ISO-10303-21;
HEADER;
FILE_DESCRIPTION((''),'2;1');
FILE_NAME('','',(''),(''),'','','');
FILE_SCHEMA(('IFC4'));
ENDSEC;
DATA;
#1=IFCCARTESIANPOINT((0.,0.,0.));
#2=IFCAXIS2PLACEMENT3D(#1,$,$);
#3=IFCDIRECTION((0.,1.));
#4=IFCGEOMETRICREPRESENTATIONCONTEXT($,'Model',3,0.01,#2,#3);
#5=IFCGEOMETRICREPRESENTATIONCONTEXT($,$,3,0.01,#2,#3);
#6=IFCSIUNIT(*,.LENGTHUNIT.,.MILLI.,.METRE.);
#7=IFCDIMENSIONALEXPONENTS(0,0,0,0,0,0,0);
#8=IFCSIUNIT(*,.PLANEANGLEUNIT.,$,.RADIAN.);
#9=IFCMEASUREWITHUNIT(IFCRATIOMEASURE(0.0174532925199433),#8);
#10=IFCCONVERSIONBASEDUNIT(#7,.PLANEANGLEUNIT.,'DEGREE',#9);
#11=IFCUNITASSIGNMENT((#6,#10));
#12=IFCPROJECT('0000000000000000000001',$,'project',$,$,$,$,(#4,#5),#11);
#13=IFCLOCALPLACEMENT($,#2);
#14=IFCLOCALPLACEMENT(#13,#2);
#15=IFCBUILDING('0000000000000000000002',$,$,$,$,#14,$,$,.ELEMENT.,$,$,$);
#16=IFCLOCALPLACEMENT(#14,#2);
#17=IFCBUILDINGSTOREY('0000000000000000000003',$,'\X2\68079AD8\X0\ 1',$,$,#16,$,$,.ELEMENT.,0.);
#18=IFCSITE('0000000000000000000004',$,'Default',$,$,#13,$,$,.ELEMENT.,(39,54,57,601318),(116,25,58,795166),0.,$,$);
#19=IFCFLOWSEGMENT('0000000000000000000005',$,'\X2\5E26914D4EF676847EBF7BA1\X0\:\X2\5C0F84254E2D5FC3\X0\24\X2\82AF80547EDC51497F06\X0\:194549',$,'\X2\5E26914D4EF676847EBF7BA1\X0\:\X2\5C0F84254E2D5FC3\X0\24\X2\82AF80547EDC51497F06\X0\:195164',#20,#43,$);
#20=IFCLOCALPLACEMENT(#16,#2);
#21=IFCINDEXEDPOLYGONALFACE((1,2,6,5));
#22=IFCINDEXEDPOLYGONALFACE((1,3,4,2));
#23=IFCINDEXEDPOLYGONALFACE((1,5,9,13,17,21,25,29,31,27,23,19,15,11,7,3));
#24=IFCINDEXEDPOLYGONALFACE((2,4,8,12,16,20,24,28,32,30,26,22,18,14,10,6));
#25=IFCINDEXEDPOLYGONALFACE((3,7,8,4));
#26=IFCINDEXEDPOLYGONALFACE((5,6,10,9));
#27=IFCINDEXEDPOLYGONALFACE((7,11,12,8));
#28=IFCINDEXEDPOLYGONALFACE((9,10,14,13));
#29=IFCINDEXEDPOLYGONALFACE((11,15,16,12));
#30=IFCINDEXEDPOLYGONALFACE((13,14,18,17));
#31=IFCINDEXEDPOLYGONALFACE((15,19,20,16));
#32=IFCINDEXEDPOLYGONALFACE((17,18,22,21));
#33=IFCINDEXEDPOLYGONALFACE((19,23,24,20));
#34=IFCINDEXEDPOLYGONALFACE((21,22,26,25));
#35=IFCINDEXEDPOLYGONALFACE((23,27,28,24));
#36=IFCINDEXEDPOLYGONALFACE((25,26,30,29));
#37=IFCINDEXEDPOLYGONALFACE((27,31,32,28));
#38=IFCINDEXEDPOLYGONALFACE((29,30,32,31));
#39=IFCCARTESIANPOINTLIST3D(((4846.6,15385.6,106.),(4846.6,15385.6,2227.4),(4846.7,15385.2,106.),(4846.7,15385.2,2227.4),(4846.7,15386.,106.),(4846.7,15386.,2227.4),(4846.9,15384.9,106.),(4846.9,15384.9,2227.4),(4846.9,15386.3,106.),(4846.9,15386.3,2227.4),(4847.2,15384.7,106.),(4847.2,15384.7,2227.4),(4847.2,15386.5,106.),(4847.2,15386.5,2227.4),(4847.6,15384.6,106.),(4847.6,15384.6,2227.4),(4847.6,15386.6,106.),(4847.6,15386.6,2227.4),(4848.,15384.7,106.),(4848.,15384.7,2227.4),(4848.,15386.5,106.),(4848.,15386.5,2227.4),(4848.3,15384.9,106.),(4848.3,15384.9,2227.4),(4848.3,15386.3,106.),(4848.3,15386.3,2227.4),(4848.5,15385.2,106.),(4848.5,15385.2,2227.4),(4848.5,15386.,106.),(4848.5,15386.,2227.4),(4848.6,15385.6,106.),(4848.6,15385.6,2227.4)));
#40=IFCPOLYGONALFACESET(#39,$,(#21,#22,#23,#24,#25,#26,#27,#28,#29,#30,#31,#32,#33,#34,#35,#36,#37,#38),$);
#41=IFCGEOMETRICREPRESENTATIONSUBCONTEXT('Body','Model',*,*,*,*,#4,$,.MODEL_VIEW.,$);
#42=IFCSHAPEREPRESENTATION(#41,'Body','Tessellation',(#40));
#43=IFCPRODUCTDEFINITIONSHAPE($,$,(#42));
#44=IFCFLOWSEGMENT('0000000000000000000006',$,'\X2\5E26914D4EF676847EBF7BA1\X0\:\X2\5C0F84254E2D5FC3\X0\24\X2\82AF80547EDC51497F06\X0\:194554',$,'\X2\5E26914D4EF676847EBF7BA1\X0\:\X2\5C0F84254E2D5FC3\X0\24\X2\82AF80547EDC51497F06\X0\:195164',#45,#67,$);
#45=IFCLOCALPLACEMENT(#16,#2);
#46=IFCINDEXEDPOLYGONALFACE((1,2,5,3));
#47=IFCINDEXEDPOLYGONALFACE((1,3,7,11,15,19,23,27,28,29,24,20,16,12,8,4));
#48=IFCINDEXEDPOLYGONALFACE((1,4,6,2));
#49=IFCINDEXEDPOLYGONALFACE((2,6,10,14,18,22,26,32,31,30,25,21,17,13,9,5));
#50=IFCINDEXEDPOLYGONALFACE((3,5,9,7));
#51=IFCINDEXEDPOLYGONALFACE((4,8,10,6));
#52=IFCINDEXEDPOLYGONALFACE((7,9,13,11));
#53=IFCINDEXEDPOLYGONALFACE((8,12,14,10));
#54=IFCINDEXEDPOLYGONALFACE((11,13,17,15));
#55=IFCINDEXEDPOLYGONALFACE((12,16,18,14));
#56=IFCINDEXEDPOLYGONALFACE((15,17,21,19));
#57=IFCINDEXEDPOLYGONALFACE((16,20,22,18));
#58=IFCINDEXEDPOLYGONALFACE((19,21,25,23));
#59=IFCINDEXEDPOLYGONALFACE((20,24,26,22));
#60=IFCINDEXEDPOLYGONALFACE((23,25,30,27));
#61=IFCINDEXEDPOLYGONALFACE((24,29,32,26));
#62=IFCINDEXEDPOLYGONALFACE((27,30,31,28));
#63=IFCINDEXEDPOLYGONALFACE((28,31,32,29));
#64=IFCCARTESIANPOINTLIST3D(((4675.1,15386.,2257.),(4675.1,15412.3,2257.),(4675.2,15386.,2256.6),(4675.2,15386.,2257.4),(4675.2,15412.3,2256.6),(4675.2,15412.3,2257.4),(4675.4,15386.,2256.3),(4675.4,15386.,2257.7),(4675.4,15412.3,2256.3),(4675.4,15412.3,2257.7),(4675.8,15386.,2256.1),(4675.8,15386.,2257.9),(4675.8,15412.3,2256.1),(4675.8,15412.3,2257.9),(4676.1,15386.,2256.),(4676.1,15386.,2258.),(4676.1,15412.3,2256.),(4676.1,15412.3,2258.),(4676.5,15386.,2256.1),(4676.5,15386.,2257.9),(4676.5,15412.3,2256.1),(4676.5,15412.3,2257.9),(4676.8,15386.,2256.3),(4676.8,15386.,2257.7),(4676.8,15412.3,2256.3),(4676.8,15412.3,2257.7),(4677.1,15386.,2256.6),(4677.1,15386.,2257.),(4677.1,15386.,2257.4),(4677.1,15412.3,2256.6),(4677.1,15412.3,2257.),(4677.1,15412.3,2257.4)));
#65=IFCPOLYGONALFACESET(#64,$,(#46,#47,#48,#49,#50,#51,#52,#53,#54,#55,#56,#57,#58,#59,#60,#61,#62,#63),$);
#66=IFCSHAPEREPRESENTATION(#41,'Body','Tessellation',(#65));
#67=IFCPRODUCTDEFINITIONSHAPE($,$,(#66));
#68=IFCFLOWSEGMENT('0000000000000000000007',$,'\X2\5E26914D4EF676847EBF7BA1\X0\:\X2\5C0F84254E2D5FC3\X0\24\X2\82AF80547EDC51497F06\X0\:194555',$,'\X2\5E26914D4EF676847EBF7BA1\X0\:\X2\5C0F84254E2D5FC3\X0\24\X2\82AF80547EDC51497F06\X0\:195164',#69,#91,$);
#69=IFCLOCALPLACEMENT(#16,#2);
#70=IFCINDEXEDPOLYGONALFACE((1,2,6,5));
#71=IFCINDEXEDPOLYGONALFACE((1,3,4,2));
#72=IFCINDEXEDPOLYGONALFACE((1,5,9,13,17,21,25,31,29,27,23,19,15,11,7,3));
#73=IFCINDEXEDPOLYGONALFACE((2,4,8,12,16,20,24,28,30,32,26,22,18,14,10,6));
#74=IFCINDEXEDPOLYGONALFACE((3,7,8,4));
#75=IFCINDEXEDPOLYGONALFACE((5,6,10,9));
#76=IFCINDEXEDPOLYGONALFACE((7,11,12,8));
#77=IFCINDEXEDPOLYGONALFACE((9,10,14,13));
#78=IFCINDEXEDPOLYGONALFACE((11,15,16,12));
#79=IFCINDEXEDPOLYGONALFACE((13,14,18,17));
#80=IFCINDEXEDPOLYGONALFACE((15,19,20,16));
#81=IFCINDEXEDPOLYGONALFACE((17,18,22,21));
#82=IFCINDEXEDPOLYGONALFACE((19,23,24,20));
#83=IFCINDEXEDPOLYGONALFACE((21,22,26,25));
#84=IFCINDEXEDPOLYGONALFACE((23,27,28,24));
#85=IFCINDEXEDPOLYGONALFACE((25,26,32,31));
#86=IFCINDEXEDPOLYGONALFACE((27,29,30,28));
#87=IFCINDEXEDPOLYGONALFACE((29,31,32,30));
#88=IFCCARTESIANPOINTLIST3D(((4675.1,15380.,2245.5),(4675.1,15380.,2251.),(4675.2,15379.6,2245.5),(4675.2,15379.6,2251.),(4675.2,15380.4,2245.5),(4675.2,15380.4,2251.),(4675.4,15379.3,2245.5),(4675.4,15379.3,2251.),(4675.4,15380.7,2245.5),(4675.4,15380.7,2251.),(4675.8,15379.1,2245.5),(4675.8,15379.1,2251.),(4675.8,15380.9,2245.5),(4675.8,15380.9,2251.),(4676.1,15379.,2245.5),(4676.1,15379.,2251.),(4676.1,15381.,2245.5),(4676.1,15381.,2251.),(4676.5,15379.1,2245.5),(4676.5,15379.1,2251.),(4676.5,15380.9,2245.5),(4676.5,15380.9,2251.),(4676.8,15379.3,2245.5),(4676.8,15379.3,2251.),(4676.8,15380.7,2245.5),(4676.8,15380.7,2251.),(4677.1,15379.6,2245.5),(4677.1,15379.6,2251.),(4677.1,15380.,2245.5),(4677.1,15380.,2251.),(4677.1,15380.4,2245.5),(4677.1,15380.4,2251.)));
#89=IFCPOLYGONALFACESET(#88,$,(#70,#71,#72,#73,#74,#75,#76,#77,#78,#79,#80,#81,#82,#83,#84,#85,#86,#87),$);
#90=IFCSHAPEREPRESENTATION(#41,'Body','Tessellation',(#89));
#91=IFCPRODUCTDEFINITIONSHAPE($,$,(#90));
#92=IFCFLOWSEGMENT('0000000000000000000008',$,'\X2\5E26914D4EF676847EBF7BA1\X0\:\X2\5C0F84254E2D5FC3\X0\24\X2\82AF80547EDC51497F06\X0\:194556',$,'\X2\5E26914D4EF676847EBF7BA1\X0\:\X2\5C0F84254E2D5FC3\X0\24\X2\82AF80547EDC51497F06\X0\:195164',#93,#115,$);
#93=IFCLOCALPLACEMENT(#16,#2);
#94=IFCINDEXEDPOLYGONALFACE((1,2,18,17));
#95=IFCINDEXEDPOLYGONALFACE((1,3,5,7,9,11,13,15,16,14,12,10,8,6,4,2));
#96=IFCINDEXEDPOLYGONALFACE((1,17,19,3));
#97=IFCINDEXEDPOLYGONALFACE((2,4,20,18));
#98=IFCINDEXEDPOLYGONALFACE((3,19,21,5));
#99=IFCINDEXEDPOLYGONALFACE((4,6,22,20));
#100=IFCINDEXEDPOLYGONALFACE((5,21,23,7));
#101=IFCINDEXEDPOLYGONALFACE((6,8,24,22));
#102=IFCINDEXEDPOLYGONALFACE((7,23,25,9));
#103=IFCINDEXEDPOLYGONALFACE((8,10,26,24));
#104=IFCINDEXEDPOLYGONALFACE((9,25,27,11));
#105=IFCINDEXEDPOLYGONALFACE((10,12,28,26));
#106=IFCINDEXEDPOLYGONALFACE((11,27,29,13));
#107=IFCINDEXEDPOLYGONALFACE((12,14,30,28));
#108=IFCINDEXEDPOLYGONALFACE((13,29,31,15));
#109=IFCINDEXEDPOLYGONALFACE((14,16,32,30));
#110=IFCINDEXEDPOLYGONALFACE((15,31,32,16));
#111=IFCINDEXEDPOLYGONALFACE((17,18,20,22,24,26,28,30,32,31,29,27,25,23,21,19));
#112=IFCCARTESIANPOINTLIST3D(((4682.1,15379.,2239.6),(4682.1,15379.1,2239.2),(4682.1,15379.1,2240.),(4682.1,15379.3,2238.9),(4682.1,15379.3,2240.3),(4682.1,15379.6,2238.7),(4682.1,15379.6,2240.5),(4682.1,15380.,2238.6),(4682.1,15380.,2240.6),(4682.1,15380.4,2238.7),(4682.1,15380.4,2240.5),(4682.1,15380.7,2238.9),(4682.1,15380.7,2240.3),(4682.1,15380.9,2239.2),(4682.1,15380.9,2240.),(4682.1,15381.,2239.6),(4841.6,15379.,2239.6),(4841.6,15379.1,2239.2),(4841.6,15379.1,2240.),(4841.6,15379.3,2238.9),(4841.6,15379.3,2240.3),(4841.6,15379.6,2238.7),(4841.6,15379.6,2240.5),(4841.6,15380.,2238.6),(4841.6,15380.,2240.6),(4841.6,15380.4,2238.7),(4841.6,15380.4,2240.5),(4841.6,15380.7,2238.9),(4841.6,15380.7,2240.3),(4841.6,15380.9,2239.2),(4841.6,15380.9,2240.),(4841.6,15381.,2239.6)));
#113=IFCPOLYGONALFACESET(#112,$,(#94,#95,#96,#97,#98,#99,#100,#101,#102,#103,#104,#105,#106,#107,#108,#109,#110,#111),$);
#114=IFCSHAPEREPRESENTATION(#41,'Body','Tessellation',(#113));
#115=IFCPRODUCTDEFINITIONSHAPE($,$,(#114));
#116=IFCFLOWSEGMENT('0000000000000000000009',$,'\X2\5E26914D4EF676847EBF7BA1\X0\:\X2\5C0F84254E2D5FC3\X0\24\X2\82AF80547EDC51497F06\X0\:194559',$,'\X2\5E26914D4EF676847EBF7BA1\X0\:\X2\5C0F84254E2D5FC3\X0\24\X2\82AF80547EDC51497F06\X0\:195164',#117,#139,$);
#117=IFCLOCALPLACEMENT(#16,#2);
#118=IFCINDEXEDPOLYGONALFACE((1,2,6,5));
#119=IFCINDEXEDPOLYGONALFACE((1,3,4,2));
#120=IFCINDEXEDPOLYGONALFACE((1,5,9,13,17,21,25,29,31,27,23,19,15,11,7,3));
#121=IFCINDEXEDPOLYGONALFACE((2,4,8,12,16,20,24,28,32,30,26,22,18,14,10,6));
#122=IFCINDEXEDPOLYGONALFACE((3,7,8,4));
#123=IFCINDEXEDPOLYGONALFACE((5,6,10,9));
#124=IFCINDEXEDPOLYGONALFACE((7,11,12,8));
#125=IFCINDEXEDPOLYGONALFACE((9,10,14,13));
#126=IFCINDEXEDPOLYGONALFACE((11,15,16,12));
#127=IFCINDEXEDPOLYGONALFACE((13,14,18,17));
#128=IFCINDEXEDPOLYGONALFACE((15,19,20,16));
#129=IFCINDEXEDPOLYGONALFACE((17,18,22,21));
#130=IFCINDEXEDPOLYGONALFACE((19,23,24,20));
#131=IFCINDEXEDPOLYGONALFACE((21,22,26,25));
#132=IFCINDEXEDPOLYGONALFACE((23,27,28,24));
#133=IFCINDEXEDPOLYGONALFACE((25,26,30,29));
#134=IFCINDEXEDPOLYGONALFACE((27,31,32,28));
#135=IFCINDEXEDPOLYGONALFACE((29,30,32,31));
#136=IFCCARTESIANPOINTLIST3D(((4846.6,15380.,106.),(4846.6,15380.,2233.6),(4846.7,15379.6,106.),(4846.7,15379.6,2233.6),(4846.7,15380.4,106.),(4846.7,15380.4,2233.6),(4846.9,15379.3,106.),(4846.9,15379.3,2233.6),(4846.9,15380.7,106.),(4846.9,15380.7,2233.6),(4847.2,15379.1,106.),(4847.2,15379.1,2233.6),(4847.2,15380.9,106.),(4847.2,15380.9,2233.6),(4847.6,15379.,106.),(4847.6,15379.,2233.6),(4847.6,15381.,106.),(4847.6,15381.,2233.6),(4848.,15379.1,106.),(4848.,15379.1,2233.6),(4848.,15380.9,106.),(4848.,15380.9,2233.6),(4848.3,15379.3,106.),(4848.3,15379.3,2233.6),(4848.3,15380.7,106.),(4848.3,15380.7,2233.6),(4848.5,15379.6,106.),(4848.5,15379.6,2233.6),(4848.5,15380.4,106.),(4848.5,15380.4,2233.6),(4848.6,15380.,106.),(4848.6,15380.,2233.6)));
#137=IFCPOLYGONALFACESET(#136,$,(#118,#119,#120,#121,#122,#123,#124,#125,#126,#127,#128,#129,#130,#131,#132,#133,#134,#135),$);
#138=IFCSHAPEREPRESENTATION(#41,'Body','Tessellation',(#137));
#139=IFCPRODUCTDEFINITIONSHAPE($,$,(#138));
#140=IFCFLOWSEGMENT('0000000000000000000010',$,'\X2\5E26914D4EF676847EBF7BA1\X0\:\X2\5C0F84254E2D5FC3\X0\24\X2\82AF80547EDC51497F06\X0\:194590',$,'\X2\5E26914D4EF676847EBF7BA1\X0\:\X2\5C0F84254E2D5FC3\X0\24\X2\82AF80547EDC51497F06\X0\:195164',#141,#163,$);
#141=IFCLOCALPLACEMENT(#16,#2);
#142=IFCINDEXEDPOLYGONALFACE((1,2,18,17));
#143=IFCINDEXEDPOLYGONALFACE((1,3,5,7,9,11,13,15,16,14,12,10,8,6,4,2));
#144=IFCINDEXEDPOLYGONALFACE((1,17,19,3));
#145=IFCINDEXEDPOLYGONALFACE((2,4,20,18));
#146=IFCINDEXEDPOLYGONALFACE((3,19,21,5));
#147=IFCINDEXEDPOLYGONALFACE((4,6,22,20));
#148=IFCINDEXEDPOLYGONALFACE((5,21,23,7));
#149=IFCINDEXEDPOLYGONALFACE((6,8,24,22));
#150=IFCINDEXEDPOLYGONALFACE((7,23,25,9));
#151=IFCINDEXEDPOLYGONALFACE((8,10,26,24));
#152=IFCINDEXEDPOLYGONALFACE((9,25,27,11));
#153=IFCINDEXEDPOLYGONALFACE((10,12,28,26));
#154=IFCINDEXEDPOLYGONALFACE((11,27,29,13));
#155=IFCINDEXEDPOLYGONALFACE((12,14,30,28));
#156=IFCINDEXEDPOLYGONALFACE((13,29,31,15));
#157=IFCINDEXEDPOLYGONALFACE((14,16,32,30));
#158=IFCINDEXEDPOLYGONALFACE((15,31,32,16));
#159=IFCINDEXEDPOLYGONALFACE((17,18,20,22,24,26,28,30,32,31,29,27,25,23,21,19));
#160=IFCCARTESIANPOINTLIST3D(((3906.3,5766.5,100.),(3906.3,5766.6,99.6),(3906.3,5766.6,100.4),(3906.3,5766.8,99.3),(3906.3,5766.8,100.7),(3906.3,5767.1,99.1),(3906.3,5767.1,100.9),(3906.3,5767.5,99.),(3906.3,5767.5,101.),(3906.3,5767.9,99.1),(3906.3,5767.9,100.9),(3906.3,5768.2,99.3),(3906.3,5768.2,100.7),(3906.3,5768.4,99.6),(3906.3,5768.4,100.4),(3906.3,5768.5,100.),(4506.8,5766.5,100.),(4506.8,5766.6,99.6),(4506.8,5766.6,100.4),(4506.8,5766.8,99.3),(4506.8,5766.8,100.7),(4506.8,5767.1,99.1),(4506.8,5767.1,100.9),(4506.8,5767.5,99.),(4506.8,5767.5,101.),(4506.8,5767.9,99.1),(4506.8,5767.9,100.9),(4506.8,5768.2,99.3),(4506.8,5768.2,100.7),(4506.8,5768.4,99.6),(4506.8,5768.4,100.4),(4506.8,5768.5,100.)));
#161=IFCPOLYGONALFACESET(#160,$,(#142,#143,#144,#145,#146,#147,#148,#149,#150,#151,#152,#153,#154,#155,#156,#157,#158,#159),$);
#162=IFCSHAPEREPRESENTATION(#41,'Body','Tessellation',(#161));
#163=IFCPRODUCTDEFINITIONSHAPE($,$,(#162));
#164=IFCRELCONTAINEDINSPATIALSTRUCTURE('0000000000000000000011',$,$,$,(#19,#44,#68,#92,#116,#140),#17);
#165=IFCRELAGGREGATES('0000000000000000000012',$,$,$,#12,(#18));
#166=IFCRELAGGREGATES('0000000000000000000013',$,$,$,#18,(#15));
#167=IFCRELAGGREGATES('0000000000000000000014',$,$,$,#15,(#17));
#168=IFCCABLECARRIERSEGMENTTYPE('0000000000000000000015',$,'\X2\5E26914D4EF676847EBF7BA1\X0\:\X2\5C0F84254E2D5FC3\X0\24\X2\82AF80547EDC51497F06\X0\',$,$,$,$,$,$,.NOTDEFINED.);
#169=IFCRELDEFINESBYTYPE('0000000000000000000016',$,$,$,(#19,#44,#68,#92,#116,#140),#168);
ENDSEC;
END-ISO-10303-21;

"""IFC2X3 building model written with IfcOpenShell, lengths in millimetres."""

from ifc_helpers import new_model, entity, si_unit, converted_unit, direction, frame, frame_2d, origin, origin_2d_with_axis, place, context, subcontext, project, spatial, circle, extrude, type_object, element, save


model = new_model("IFC2X3")

# Units and contexts
model_context = context("Model", 3, precision=0.01, world=origin(), true_north=direction((0.0, 1.0)))
context_of_model = context(None, 3, precision=0.01, world=origin(), true_north=direction((0.0, 1.0)))
body_context = subcontext(model_context, "Body", "Model", "MODEL_VIEW")
ifc_project = project(units=[si_unit("LENGTHUNIT", "METRE", prefix="MILLI"), converted_unit("PLANEANGLEUNIT", "DEGREE", entity("IfcRatioMeasure", 0.0174532925199433), si_unit("PLANEANGLEUNIT", "RADIAN"), dimensions=[0, 0, 0, 0, 0, 0, 0])], contexts=[model_context, context_of_model])

# Site, building, storey
site_placement = place(None, origin())
site = spatial("IfcSite", under=ifc_project, at=site_placement, Name="Default", CompositionType="ELEMENT", RefLatitude=(39, 54, 57, 601318), RefLongitude=(116, 25, 58, 795166), RefElevation=0.0)
building_placement = place(site_placement, origin())
building = spatial("IfcBuilding", under=site, at=building_placement, CompositionType="ELEMENT")
storey_placement = place(building_placement, origin())
storey = spatial("IfcBuildingStorey", under=building, at=storey_placement, Name="标高 1", CompositionType="ELEMENT", Elevation=0.0)

# Flow segments
cable_carrier_segment_type = type_object("IfcCableCarrierSegmentType", Name="带配件的线管:小营中心24芯联络光缆", PredefinedType="NOTDEFINED")
flow_segment_1_placement = place(storey_placement, origin())
element("IfcFlowSegment", 1, at=flow_segment_1_placement, inside=storey, type_object=cable_carrier_segment_type, Name="带配件的线管:小营中心24芯联络光缆:194549", ObjectType="带配件的线管:小营中心24芯联络光缆:195164", context=body_context, shape_type="SweptSolid", body=[
    extrude(circle(Radius=1.0, at=frame_2d((0.0, 0.0), x_axis=(1.0, 0.0))), frame((4847.6, 15385.6, 106.0)), (0.0, 0.0, 1.0), 2121.5),
])
flow_segment_2_placement = place(storey_placement, origin())
element("IfcFlowSegment", 2, at=flow_segment_2_placement, inside=storey, type_object=cable_carrier_segment_type, Name="带配件的线管:小营中心24芯联络光缆:194554", ObjectType="带配件的线管:小营中心24芯联络光缆:195164", context=body_context, shape_type="SweptSolid", body=[
    extrude(circle(Radius=1.0, at=origin_2d_with_axis()), frame((4676.1, 15386.0, 2257.0), z_axis=(0.0, 1.0, 0.0), x_axis=(1.0, 0.0, 0.0)), (0.0, 0.0, 1.0), 26.4),
])
flow_segment_3_placement = place(storey_placement, origin())
element("IfcFlowSegment", 3, at=flow_segment_3_placement, inside=storey, type_object=cable_carrier_segment_type, Name="带配件的线管:小营中心24芯联络光缆:194555", ObjectType="带配件的线管:小营中心24芯联络光缆:195164", context=body_context, shape_type="SweptSolid", body=[
    extrude(circle(Radius=1.0, at=origin_2d_with_axis()), frame((4676.1, 15380.0, 2245.5), z_axis=(0.0, 0.0, 1.0), x_axis=(-1.0, 0.0, 0.0)), (0.0, 0.0, 1.0), 5.5),
])
flow_segment_4_placement = place(storey_placement, origin())
element("IfcFlowSegment", 4, at=flow_segment_4_placement, inside=storey, type_object=cable_carrier_segment_type, Name="带配件的线管:小营中心24芯联络光缆:194556", ObjectType="带配件的线管:小营中心24芯联络光缆:195164", context=body_context, shape_type="SweptSolid", body=[
    extrude(circle(Radius=1.0, at=frame_2d((0.0, 0.0), x_axis=(1.0, 0.0))), frame((4682.1, 15380.0, 2239.6), z_axis=(1.0, 0.0, 0.0), x_axis=(0.0, 1.0, 0.0)), (0.0, 0.0, 1.0), 159.5),
])
flow_segment_5_placement = place(storey_placement, origin())
element("IfcFlowSegment", 5, at=flow_segment_5_placement, inside=storey, type_object=cable_carrier_segment_type, Name="带配件的线管:小营中心24芯联络光缆:194559", ObjectType="带配件的线管:小营中心24芯联络光缆:195164", context=body_context, shape_type="SweptSolid", body=[
    extrude(circle(Radius=1.0, at=frame_2d((0.0, 0.0), x_axis=(1.0, 0.0))), frame((4847.6, 15380.0, 106.0)), (0.0, 0.0, 1.0), 2127.7),
])
flow_segment_6_placement = place(storey_placement, origin())
element("IfcFlowSegment", 6, at=flow_segment_6_placement, inside=storey, type_object=cable_carrier_segment_type, Name="带配件的线管:小营中心24芯联络光缆:194590", ObjectType="带配件的线管:小营中心24芯联络光缆:195164", context=body_context, shape_type="SweptSolid", body=[
    extrude(circle(Radius=1.0, at=frame_2d((0.0, 0.0), x_axis=(1.0, 0.0))), frame((3906.3, 5767.5, 100.0), z_axis=(1.0, 0.0, 0.0), x_axis=(0.0, 1.0, 0.0)), (0.0, 0.0, 1.0), 600.5),
])

save(model, "model.ifc")
